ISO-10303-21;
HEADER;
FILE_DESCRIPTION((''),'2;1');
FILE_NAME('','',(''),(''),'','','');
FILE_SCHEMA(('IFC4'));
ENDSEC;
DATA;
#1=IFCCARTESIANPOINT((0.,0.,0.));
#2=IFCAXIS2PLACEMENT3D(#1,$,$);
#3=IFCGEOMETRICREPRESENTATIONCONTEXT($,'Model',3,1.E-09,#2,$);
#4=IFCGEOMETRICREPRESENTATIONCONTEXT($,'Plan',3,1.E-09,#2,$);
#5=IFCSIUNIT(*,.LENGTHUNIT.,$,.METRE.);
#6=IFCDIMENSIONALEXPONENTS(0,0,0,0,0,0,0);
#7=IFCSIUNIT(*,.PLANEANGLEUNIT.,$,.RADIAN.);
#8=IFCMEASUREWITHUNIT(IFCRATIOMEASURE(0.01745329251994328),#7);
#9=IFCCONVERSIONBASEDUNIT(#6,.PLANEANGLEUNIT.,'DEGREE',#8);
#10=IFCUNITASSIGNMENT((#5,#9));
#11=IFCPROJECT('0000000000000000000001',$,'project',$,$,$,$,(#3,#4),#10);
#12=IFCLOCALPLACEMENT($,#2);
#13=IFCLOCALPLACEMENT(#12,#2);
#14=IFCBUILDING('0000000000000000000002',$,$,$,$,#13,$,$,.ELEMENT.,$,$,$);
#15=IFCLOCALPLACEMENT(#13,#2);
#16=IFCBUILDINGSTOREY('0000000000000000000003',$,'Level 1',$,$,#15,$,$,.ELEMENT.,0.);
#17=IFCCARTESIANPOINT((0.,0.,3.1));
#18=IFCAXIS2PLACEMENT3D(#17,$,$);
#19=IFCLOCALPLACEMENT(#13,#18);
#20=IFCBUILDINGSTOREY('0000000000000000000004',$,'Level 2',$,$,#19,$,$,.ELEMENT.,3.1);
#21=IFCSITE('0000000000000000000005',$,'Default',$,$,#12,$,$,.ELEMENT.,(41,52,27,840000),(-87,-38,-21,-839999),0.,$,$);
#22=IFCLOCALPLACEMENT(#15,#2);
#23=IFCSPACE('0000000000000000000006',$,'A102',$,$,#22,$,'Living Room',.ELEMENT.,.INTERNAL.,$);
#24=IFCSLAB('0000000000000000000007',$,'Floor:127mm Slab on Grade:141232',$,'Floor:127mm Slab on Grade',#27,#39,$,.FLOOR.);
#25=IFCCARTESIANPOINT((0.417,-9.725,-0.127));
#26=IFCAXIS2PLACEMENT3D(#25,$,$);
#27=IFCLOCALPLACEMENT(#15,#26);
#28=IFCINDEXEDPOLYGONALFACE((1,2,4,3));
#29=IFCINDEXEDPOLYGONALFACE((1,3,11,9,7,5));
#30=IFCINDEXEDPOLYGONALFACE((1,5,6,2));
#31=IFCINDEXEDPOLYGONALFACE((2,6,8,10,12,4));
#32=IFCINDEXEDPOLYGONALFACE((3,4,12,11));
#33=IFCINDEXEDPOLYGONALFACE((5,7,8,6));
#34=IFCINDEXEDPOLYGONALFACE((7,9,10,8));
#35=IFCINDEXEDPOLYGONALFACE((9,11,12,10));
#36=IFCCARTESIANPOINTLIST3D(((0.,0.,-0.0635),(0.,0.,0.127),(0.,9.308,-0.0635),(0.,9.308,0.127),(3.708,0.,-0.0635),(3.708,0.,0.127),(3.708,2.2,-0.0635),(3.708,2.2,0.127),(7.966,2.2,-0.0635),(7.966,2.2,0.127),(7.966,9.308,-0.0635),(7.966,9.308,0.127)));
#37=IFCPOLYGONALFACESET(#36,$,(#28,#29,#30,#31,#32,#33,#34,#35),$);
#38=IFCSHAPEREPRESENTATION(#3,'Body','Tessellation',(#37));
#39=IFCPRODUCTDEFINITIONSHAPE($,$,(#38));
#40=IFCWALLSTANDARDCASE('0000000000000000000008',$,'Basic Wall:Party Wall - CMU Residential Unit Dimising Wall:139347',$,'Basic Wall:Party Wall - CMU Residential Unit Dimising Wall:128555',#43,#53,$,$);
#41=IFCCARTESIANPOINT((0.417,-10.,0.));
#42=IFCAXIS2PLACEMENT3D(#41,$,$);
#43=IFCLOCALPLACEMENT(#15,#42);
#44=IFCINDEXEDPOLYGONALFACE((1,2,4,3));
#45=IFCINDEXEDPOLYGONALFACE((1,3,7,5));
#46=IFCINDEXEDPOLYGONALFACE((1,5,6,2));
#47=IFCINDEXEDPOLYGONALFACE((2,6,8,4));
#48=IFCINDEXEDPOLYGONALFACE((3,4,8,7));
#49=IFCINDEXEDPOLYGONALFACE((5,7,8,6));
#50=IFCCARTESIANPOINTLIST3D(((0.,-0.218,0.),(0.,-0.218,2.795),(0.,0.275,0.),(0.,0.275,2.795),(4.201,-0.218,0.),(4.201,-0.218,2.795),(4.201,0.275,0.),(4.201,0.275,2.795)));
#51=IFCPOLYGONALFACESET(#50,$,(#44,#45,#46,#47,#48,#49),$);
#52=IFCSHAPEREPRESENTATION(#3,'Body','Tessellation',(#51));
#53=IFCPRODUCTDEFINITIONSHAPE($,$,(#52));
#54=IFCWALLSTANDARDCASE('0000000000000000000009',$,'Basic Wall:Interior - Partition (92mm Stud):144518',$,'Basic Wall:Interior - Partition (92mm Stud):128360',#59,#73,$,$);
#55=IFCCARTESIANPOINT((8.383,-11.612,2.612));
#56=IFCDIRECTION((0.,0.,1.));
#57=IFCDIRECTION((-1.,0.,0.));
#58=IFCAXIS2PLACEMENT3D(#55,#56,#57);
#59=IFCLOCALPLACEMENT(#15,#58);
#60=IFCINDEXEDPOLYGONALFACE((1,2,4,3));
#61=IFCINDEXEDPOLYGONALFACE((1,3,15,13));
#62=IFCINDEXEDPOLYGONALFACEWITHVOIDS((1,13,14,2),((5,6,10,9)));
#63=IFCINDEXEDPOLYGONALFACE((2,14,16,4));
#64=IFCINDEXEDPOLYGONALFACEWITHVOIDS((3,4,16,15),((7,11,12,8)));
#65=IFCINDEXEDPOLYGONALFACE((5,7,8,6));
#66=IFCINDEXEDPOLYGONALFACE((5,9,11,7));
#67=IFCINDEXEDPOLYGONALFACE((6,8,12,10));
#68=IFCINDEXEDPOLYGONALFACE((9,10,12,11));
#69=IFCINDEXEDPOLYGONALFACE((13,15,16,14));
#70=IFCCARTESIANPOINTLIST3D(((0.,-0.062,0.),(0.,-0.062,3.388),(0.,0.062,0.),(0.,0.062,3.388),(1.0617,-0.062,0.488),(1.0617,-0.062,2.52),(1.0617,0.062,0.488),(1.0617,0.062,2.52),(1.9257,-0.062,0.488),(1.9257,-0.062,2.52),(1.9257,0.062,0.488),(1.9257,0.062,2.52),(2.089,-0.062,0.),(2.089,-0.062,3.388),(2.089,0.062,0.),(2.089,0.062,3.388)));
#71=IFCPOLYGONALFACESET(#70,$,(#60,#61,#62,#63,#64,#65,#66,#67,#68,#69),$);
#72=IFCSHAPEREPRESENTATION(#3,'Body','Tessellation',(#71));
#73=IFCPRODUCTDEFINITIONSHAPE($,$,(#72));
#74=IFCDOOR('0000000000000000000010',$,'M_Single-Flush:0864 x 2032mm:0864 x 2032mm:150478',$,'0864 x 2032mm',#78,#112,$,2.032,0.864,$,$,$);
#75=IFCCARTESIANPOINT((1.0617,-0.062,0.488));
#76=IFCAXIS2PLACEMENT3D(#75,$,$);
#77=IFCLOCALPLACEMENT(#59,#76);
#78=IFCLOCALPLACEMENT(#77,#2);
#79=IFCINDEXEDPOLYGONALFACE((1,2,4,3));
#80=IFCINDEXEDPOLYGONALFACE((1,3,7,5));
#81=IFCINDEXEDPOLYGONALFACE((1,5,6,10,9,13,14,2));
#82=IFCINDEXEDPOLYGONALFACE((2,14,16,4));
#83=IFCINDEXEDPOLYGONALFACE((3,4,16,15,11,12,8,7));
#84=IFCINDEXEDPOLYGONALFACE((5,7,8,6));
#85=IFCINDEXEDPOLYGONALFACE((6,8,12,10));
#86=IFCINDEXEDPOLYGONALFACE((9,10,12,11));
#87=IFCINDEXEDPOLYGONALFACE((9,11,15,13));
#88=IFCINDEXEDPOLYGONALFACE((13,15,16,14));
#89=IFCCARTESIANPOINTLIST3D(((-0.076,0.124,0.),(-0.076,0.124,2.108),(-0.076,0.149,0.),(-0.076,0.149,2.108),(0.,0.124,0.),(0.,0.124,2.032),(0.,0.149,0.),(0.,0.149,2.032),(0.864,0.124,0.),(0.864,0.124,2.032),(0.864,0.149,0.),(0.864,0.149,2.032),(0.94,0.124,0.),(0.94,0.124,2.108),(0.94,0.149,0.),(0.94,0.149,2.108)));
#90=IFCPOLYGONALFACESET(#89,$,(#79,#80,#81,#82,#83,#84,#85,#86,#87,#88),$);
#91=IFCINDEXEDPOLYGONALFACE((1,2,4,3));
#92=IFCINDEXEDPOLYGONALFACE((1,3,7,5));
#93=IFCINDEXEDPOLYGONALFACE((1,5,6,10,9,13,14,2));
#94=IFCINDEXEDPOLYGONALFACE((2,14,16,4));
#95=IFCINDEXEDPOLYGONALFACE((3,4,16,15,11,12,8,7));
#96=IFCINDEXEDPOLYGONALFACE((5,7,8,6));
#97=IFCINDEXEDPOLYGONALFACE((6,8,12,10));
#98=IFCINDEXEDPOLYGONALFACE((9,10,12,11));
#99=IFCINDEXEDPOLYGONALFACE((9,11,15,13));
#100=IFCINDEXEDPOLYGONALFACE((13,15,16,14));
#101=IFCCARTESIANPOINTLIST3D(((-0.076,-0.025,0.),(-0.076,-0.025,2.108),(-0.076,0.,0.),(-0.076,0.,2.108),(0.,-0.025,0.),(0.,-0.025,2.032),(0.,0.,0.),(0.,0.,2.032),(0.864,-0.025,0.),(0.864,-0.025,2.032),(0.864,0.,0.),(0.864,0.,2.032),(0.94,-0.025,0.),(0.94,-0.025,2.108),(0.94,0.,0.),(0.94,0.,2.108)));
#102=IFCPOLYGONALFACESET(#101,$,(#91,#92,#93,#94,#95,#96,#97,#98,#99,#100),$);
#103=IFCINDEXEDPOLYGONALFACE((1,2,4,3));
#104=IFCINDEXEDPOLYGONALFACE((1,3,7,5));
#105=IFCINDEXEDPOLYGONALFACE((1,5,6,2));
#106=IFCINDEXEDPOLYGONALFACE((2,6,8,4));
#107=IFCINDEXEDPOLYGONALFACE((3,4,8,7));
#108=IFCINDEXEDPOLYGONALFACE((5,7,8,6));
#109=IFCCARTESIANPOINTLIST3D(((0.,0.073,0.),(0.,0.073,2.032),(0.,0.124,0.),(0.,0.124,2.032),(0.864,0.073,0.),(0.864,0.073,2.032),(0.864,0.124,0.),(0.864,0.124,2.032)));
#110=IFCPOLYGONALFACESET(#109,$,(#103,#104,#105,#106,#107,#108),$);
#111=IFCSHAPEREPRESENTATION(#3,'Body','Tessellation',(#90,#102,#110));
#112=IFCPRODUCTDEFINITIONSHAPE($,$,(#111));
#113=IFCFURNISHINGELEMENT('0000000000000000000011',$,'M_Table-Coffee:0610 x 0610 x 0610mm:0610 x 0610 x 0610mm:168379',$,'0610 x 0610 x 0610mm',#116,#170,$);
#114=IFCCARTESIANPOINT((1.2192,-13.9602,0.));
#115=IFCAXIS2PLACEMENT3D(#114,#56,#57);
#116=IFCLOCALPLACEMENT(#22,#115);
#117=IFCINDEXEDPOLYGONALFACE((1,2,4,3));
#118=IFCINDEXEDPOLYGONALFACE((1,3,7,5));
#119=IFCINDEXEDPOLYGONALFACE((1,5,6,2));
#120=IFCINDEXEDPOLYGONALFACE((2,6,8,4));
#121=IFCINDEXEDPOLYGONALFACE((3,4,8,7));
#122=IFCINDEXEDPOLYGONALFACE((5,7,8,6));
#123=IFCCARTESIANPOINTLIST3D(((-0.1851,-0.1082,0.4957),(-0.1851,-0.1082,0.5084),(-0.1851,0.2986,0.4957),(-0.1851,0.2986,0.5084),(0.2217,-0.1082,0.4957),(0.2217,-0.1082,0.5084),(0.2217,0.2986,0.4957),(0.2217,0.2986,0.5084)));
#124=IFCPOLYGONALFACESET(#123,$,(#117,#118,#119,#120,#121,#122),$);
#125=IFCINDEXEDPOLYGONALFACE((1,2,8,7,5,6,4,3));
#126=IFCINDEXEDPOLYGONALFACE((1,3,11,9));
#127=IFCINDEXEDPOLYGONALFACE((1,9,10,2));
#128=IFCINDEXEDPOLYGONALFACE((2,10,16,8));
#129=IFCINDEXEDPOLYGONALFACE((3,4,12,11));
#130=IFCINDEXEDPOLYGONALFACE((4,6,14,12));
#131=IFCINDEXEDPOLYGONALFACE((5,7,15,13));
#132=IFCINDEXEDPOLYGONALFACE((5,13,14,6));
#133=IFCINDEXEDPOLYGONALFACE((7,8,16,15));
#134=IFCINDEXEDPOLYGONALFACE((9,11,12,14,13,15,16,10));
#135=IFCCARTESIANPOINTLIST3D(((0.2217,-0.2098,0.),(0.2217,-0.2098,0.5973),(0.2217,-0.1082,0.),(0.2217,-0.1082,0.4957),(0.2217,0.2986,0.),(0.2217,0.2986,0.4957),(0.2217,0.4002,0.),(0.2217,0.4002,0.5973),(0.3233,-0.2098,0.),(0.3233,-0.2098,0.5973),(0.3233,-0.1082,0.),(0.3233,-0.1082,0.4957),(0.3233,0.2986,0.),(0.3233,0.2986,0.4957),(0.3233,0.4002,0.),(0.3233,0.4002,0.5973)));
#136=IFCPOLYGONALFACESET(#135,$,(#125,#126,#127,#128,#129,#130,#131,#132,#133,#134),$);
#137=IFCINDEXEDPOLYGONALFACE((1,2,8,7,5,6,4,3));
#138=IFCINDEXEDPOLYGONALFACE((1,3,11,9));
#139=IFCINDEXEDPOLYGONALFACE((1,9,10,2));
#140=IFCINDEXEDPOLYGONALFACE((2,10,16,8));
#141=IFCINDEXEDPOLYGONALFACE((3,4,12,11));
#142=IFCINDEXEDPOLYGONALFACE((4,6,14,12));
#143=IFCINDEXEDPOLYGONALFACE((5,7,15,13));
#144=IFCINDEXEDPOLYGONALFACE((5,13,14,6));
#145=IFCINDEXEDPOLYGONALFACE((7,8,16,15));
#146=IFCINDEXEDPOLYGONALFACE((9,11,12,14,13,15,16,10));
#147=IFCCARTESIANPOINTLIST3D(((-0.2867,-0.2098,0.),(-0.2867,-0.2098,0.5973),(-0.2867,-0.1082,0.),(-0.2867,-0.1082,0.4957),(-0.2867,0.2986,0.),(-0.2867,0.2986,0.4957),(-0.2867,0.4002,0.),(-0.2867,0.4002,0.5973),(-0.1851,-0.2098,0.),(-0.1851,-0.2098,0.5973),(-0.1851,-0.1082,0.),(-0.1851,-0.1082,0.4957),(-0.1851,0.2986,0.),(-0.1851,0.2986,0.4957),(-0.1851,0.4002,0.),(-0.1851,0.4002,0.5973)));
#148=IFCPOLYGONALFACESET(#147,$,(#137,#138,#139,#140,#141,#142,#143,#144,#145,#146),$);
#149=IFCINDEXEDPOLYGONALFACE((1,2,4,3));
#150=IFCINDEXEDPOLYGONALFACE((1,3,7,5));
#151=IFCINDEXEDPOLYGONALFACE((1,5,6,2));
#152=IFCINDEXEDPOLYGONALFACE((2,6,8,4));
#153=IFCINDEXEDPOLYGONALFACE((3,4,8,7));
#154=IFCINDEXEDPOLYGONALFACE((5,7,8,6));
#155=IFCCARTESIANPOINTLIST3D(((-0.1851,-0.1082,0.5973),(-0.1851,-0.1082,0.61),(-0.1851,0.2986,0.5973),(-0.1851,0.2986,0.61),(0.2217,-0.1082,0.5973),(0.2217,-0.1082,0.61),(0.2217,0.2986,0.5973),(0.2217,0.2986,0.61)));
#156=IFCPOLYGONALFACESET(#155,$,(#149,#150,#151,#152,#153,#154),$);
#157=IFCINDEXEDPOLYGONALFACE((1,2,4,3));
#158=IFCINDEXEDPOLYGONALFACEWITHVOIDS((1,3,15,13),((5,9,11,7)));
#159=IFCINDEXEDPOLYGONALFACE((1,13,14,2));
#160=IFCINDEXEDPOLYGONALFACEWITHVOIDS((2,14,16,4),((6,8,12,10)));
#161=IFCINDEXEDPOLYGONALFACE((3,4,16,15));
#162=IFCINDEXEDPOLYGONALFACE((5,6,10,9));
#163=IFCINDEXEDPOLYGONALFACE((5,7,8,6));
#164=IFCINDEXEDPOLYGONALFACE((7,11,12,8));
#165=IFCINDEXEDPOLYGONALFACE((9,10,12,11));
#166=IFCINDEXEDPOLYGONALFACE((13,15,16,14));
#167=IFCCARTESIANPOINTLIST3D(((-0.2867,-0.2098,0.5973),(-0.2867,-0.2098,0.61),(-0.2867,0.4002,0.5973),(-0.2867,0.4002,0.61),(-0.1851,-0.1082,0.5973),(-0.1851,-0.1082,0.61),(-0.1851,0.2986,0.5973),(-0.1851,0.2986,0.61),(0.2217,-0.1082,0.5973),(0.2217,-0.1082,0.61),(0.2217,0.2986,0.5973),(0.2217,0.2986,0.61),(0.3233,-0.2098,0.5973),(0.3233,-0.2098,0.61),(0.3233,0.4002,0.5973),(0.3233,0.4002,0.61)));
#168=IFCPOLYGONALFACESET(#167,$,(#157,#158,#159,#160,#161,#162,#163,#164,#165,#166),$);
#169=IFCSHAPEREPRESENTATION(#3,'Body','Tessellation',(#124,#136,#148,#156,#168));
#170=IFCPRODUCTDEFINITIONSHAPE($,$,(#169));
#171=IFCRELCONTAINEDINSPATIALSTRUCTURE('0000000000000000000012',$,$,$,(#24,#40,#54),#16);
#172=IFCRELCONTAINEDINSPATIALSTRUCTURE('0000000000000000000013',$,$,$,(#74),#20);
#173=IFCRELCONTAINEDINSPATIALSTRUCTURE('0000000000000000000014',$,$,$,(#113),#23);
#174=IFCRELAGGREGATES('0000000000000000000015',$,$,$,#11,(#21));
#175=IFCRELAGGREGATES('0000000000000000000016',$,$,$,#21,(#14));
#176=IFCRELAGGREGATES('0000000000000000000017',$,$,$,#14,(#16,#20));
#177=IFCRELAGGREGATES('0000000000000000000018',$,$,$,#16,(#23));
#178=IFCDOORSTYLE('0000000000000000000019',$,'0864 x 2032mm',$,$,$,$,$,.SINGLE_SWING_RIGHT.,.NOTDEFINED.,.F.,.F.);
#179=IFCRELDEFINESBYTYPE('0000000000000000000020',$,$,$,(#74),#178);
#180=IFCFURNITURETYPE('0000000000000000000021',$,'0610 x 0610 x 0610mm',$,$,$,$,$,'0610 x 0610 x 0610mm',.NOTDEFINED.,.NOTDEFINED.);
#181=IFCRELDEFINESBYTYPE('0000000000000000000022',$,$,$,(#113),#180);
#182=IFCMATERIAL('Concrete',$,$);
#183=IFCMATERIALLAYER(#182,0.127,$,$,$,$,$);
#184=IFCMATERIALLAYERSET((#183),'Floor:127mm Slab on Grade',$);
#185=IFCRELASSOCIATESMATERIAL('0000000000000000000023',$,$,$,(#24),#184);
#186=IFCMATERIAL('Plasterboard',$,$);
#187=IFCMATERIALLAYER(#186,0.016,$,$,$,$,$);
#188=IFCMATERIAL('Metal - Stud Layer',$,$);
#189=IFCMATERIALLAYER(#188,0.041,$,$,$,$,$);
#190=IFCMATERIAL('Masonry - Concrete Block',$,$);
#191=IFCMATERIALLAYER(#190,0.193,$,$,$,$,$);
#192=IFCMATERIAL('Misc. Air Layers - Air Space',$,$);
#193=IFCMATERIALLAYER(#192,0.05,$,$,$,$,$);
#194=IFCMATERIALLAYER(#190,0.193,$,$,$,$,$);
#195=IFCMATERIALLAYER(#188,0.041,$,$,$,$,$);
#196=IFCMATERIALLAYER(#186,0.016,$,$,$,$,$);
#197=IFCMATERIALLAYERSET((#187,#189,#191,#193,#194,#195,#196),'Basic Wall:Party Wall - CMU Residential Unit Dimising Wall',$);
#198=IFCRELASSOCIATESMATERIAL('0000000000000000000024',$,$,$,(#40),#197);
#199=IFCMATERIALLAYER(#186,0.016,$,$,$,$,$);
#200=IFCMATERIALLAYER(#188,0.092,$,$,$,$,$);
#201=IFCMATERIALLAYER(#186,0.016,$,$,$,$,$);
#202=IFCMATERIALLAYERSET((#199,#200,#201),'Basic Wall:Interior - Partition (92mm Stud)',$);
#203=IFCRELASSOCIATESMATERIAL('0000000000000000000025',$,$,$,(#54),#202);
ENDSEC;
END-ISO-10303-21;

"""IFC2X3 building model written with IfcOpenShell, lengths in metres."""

from ifc_helpers import new_model, entity, si_unit, converted_unit, frame, frame_2d, origin, origin_2d_with_axis, place, context, project, spatial, polyline, rectangle, outline, extrude, clip, bounded_halfspace, source, transform, mapped, material, layer, layer_set, layer_usage, type_object, type_shapes, element, fill, save


model = new_model("IFC2X3")

# Units and contexts
model_context = context("Model", 3, precision=1e-09, world=origin())
plan_context = context("Plan", 3, precision=1e-09, world=origin())
ifc_project = project(units=[si_unit("LENGTHUNIT", "METRE"), converted_unit("PLANEANGLEUNIT", "DEGREE", entity("IfcRatioMeasure", 0.01745329251994328), si_unit("PLANEANGLEUNIT", "RADIAN"), dimensions=[0, 0, 0, 0, 0, 0, 0])], contexts=[model_context, plan_context])

# Site, building, storey
site_placement = place(None, origin())
site = spatial("IfcSite", under=ifc_project, at=site_placement, Name="Default", CompositionType="ELEMENT", RefLatitude=(41, 52, 27, 840000), RefLongitude=(-87, -38, -21, -839999), RefElevation=0.0)
building_placement = place(site_placement, origin())
building = spatial("IfcBuilding", under=site, at=building_placement, CompositionType="ELEMENT")
storey_1_placement = place(building_placement, origin())
storey_1 = spatial("IfcBuildingStorey", under=building, at=storey_1_placement, Name="Level 1", CompositionType="ELEMENT", Elevation=0.0)

# Slab
ifc_material_1 = material(Name="Concrete")
ifc_layer_1 = layer(ifc_material_1, 0.127)
ifc_layer_set_1 = layer_set([ifc_layer_1], Name="Floor:127mm Slab on Grade")
ifc_layer_usage_1 = layer_usage(ifc_layer_set_1, "AXIS3", "POSITIVE", 0.0)
slab_1_placement = place(storey_1_placement, frame((0.417, -9.725, -0.127)))
element("IfcSlab", 1, at=slab_1_placement, inside=storey_1, material=ifc_layer_usage_1, Name="Floor:127mm Slab on Grade:141232", ObjectType="Floor:127mm Slab on Grade", PredefinedType="FLOOR", context=model_context, shape_type="SweptSolid", body=[
    extrude(outline(polyline([(-3.983, 4.654), (-3.983, -2.454), (0.275, -2.454), (0.275, -4.654), (3.983, -4.654), (3.983, 4.654), (-3.983, 4.654)])), frame((3.983, 4.654, 0.127), z_axis=(0.0, 0.0, -1.0), x_axis=(-1.0, 0.0, 0.0)), (0.0, 0.0, 1.0), 0.1905),
])

# Shared definitions
ifc_material_2 = material(Name="Misc. Air Layers - Air Space")
ifc_material_3 = material(Name="Masonry - Concrete Block")
ifc_material_4 = material(Name="Metal - Stud Layer")
ifc_material_5 = material(Name="Plasterboard")

# Wall
ifc_layer_2 = layer(ifc_material_5, 0.016)
ifc_layer_3 = layer(ifc_material_4, 0.041)
ifc_layer_4 = layer(ifc_material_3, 0.193)
ifc_layer_5 = layer(ifc_material_2, 0.05)
ifc_layer_6 = layer(ifc_material_3, 0.193)
ifc_layer_7 = layer(ifc_material_4, 0.041)
ifc_layer_8 = layer(ifc_material_5, 0.016)
ifc_layer_set_2 = layer_set([ifc_layer_2, ifc_layer_3, ifc_layer_4, ifc_layer_5, ifc_layer_6, ifc_layer_7, ifc_layer_8], Name="Basic Wall:Party Wall - CMU Residential Unit Dimising Wall")
ifc_layer_usage_2 = layer_usage(ifc_layer_set_2, "AXIS2", "NEGATIVE", 0.275)
wall_1_placement = place(storey_1_placement, frame((0.417, -10.0, 0.0)))
element("IfcWallStandardCase", 2, at=wall_1_placement, inside=storey_1, material=ifc_layer_usage_2, Name="Basic Wall:Party Wall - CMU Residential Unit Dimising Wall:139347", ObjectType="Basic Wall:Party Wall - CMU Residential Unit Dimising Wall:128555", context=model_context, shape_type="Clipping", body=[
    clip(clip(extrude(rectangle(XDim=4.201, YDim=0.55, at=frame_2d((2.1005, 0.0), x_axis=(-1.0, 0.0))), origin(), (0.0, 0.0, 1.0), 2.795), bounded_halfspace(frame((0.0, -0.218, 0.0), z_axis=(0.0, 1.0, 0.0), x_axis=(-1.0, 0.0, 0.0)), True, frame((0.0, -0.218, 0.0), z_axis=(0.0, 1.0, 0.0), x_axis=(-1.0, 0.0, 0.0)), polyline([(0.0, 0.0), (0.0, 2.795), (-4.201, 2.795), (-4.201, 0.0), (0.0, 0.0)]))), bounded_halfspace(frame((4.201, 0.275, 0.0), z_axis=(-1.0, 0.0, 0.0), x_axis=(0.0, -1.0, 0.0)), True, frame((4.201, 0.275, 0.0), z_axis=(-1.0, 0.0, 0.0), x_axis=(0.0, -1.0, 0.0)), polyline([(0.0, 0.0), (0.493, 0.0), (0.493, 2.795), (0.0, 2.795), (0.0, 0.0)]))),
])

# Shared definitions
ifc_layer_9 = layer(ifc_material_5, 0.016)
ifc_layer_10 = layer(ifc_material_4, 0.092)
ifc_layer_11 = layer(ifc_material_5, 0.016)
ifc_layer_set_3 = layer_set([ifc_layer_9, ifc_layer_10, ifc_layer_11], Name="Basic Wall:Interior - Partition (92mm Stud)")

# Wall, opening
ifc_layer_usage_3 = layer_usage(ifc_layer_set_3, "AXIS2", "NEGATIVE", 0.062)
wall_2_placement = place(storey_1_placement, frame((8.383, -11.612, 2.612), z_axis=(0.0, 0.0, 1.0), x_axis=(-1.0, 0.0, 0.0)))
wall_2 = element("IfcWallStandardCase", 3, at=wall_2_placement, inside=storey_1, material=ifc_layer_usage_3, Name="Basic Wall:Interior - Partition (92mm Stud):144518", ObjectType="Basic Wall:Interior - Partition (92mm Stud):128360", context=model_context, shape_type="SweptSolid", body=[
    extrude(rectangle(XDim=2.089, YDim=0.124, at=frame_2d((1.0445, 0.0), x_axis=(-1.0, 0.0))), origin(), (0.0, 0.0, 1.0), 3.388),
])
opening_1_placement = place(wall_2_placement, frame((1.0617, -0.062, 0.488)))
opening_1 = element("IfcOpeningElement", 4, at=opening_1_placement, cuts=wall_2, ObjectType="Opening", context=model_context, shape_type="SweptSolid", body=[
    extrude(rectangle(XDim=0.864, YDim=2.032, at=frame_2d((1.016, 0.432), x_axis=(0.0, 1.0))), frame((0.0, 0.0, 0.0), z_axis=(0.0, 1.0, 0.0), x_axis=(0.0, 0.0, 1.0)), (0.0, 0.0, 1.0), 0.124),
])

# Shared definitions
storey_2_placement = place(building_placement, frame((0.0, 0.0, 3.1)))
storey_2 = spatial("IfcBuildingStorey", under=building, at=storey_2_placement, Name="Level 2", CompositionType="ELEMENT", Elevation=3.1)

# Door
door_style_1 = type_object("IfcDoorStyle", Name="0864 x 2032mm", ConstructionType="NOTDEFINED", OperationType="SINGLE_SWING_RIGHT", ParameterTakesPrecedence=False, Sizeable=False)
shared_shape_1 = source(origin(), model_context, "Body", "SweptSolid", [
    extrude(outline(polyline([(-0.508, -1.073), (0.508, -1.073), (0.508, 1.035), (0.432, 1.035), (0.432, -0.997), (-0.432, -0.997), (-0.432, 1.035), (-0.508, 1.035), (-0.508, -1.073)])), frame((0.432, 0.124, 1.035), z_axis=(0.0, 1.0, 0.0), x_axis=(1.0, 0.0, 0.0)), (0.0, 0.0, 1.0), 0.025),
    extrude(outline(polyline([(-1.073, -0.508), (1.035, -0.508), (1.035, -0.432), (-0.997, -0.432), (-0.997, 0.432), (1.035, 0.432), (1.035, 0.508), (-1.073, 0.508), (-1.073, -0.508)])), frame((0.432, -0.025, 1.035), z_axis=(0.0, 1.0, 0.0), x_axis=(0.0, 0.0, -1.0)), (0.0, 0.0, 1.0), 0.025),
    extrude(rectangle(XDim=0.051, YDim=0.864, at=origin_2d_with_axis()), frame((0.432, 0.0985, 0.0), z_axis=(0.0, 0.0, 1.0), x_axis=(0.0, 1.0, 0.0)), (0.0, 0.0, 1.0), 2.032),
])
type_shapes(door_style_1, [shared_shape_1])
door_1_placement = place(opening_1_placement, origin())
door_1 = element("IfcDoor", 5, at=door_1_placement, inside=storey_2, type_object=door_style_1, Name="M_Single-Flush:0864 x 2032mm:0864 x 2032mm:150478", ObjectType="0864 x 2032mm", OverallHeight=2.032, OverallWidth=0.864, context=model_context, shape_type="MappedRepresentation", body=[
    mapped(shared_shape_1, transform((0.0, 0.0, 0.0), scale=1.0)),
])
fill(opening_1, door_1)

# Shared definitions
space_1_placement = place(storey_1_placement, origin())
space_1 = spatial("IfcSpace", under=storey_1, at=space_1_placement, Name="A102", LongName="Living Room", CompositionType="ELEMENT", InteriorOrExteriorSpace="INTERNAL")

# Furnishing element
furniture_type_1 = type_object("IfcFurnitureType", Name="0610 x 0610 x 0610mm", ElementType="0610 x 0610 x 0610mm", AssemblyPlace="NOTDEFINED")
shared_shape_2 = source(origin(), model_context, "Body", "SweptSolid", [
    extrude(rectangle(XDim=0.4068, YDim=0.4068, at=origin_2d_with_axis()), frame((0.0183, 0.0952, 0.4957), z_axis=(0.0, 0.0, 1.0), x_axis=(-1.0, 0.0, 0.0)), (0.0, 0.0, 1.0), 0.0127),
    extrude(outline(polyline([(-0.2732, -0.305), (0.324, -0.305), (0.324, 0.305), (-0.2732, 0.305), (-0.2732, 0.2034), (0.2225, 0.2034), (0.2225, -0.2034), (-0.2732, -0.2034), (-0.2732, -0.305)])), frame((0.2217, 0.0952, 0.2732), z_axis=(1.0, 0.0, 0.0), x_axis=(0.0, 0.0, 1.0)), (0.0, 0.0, 1.0), 0.1016),
    extrude(outline(polyline([(-0.305, -0.3241), (0.305, -0.3241), (0.305, 0.2733), (0.2034, 0.2733), (0.2034, -0.2224), (-0.2034, -0.2224), (-0.2034, 0.2733), (-0.305, 0.2733), (-0.305, -0.3241)])), frame((-0.2867, 0.0952, 0.2733), z_axis=(1.0, 0.0, 0.0), x_axis=(0.0, -1.0, 0.0)), (0.0, 0.0, 1.0), 0.1016),
    extrude(rectangle(XDim=0.4068, YDim=0.4068, at=origin_2d_with_axis()), frame((0.0183, 0.0952, 0.5973), z_axis=(0.0, 0.0, 1.0), x_axis=(-1.0, 0.0, 0.0)), (0.0, 0.0, 1.0), 0.0127),
    extrude(outline(polyline([(-0.305, -0.305), (0.305, -0.305), (0.305, 0.305), (-0.305, 0.305), (-0.305, -0.305)]), holes=[polyline([(-0.2034, -0.2034), (-0.2034, 0.2034), (0.2034, 0.2034), (0.2034, -0.2034), (-0.2034, -0.2034)])]), frame((0.0183, 0.0952, 0.5973), z_axis=(0.0, 0.0, 1.0), x_axis=(-1.0, 0.0, 0.0)), (0.0, 0.0, 1.0), 0.0127),
])
type_shapes(furniture_type_1, [shared_shape_2])
for number, where, z_axis, x_axis, name in (
    (6, (1.2192, -13.9602, 0.0), (0.0, 0.0, 1.0), (-1.0, 0.0, 0.0), "M_Table-Coffee:0610 x 0610 x 0610mm:0610 x 0610 x 0610mm:168379"),
):
    element("IfcFurnishingElement", number, at=place(space_1_placement, frame(where, z_axis=z_axis, x_axis=x_axis)), inside=space_1, type_object=furniture_type_1, Name=name, ObjectType="0610 x 0610 x 0610mm", context=model_context, shape_type="MappedRepresentation", body=[
        mapped(shared_shape_2, transform((0.0, 0.0, 0.0), scale=1.0)),
    ])

save(model, "model.ifc")
